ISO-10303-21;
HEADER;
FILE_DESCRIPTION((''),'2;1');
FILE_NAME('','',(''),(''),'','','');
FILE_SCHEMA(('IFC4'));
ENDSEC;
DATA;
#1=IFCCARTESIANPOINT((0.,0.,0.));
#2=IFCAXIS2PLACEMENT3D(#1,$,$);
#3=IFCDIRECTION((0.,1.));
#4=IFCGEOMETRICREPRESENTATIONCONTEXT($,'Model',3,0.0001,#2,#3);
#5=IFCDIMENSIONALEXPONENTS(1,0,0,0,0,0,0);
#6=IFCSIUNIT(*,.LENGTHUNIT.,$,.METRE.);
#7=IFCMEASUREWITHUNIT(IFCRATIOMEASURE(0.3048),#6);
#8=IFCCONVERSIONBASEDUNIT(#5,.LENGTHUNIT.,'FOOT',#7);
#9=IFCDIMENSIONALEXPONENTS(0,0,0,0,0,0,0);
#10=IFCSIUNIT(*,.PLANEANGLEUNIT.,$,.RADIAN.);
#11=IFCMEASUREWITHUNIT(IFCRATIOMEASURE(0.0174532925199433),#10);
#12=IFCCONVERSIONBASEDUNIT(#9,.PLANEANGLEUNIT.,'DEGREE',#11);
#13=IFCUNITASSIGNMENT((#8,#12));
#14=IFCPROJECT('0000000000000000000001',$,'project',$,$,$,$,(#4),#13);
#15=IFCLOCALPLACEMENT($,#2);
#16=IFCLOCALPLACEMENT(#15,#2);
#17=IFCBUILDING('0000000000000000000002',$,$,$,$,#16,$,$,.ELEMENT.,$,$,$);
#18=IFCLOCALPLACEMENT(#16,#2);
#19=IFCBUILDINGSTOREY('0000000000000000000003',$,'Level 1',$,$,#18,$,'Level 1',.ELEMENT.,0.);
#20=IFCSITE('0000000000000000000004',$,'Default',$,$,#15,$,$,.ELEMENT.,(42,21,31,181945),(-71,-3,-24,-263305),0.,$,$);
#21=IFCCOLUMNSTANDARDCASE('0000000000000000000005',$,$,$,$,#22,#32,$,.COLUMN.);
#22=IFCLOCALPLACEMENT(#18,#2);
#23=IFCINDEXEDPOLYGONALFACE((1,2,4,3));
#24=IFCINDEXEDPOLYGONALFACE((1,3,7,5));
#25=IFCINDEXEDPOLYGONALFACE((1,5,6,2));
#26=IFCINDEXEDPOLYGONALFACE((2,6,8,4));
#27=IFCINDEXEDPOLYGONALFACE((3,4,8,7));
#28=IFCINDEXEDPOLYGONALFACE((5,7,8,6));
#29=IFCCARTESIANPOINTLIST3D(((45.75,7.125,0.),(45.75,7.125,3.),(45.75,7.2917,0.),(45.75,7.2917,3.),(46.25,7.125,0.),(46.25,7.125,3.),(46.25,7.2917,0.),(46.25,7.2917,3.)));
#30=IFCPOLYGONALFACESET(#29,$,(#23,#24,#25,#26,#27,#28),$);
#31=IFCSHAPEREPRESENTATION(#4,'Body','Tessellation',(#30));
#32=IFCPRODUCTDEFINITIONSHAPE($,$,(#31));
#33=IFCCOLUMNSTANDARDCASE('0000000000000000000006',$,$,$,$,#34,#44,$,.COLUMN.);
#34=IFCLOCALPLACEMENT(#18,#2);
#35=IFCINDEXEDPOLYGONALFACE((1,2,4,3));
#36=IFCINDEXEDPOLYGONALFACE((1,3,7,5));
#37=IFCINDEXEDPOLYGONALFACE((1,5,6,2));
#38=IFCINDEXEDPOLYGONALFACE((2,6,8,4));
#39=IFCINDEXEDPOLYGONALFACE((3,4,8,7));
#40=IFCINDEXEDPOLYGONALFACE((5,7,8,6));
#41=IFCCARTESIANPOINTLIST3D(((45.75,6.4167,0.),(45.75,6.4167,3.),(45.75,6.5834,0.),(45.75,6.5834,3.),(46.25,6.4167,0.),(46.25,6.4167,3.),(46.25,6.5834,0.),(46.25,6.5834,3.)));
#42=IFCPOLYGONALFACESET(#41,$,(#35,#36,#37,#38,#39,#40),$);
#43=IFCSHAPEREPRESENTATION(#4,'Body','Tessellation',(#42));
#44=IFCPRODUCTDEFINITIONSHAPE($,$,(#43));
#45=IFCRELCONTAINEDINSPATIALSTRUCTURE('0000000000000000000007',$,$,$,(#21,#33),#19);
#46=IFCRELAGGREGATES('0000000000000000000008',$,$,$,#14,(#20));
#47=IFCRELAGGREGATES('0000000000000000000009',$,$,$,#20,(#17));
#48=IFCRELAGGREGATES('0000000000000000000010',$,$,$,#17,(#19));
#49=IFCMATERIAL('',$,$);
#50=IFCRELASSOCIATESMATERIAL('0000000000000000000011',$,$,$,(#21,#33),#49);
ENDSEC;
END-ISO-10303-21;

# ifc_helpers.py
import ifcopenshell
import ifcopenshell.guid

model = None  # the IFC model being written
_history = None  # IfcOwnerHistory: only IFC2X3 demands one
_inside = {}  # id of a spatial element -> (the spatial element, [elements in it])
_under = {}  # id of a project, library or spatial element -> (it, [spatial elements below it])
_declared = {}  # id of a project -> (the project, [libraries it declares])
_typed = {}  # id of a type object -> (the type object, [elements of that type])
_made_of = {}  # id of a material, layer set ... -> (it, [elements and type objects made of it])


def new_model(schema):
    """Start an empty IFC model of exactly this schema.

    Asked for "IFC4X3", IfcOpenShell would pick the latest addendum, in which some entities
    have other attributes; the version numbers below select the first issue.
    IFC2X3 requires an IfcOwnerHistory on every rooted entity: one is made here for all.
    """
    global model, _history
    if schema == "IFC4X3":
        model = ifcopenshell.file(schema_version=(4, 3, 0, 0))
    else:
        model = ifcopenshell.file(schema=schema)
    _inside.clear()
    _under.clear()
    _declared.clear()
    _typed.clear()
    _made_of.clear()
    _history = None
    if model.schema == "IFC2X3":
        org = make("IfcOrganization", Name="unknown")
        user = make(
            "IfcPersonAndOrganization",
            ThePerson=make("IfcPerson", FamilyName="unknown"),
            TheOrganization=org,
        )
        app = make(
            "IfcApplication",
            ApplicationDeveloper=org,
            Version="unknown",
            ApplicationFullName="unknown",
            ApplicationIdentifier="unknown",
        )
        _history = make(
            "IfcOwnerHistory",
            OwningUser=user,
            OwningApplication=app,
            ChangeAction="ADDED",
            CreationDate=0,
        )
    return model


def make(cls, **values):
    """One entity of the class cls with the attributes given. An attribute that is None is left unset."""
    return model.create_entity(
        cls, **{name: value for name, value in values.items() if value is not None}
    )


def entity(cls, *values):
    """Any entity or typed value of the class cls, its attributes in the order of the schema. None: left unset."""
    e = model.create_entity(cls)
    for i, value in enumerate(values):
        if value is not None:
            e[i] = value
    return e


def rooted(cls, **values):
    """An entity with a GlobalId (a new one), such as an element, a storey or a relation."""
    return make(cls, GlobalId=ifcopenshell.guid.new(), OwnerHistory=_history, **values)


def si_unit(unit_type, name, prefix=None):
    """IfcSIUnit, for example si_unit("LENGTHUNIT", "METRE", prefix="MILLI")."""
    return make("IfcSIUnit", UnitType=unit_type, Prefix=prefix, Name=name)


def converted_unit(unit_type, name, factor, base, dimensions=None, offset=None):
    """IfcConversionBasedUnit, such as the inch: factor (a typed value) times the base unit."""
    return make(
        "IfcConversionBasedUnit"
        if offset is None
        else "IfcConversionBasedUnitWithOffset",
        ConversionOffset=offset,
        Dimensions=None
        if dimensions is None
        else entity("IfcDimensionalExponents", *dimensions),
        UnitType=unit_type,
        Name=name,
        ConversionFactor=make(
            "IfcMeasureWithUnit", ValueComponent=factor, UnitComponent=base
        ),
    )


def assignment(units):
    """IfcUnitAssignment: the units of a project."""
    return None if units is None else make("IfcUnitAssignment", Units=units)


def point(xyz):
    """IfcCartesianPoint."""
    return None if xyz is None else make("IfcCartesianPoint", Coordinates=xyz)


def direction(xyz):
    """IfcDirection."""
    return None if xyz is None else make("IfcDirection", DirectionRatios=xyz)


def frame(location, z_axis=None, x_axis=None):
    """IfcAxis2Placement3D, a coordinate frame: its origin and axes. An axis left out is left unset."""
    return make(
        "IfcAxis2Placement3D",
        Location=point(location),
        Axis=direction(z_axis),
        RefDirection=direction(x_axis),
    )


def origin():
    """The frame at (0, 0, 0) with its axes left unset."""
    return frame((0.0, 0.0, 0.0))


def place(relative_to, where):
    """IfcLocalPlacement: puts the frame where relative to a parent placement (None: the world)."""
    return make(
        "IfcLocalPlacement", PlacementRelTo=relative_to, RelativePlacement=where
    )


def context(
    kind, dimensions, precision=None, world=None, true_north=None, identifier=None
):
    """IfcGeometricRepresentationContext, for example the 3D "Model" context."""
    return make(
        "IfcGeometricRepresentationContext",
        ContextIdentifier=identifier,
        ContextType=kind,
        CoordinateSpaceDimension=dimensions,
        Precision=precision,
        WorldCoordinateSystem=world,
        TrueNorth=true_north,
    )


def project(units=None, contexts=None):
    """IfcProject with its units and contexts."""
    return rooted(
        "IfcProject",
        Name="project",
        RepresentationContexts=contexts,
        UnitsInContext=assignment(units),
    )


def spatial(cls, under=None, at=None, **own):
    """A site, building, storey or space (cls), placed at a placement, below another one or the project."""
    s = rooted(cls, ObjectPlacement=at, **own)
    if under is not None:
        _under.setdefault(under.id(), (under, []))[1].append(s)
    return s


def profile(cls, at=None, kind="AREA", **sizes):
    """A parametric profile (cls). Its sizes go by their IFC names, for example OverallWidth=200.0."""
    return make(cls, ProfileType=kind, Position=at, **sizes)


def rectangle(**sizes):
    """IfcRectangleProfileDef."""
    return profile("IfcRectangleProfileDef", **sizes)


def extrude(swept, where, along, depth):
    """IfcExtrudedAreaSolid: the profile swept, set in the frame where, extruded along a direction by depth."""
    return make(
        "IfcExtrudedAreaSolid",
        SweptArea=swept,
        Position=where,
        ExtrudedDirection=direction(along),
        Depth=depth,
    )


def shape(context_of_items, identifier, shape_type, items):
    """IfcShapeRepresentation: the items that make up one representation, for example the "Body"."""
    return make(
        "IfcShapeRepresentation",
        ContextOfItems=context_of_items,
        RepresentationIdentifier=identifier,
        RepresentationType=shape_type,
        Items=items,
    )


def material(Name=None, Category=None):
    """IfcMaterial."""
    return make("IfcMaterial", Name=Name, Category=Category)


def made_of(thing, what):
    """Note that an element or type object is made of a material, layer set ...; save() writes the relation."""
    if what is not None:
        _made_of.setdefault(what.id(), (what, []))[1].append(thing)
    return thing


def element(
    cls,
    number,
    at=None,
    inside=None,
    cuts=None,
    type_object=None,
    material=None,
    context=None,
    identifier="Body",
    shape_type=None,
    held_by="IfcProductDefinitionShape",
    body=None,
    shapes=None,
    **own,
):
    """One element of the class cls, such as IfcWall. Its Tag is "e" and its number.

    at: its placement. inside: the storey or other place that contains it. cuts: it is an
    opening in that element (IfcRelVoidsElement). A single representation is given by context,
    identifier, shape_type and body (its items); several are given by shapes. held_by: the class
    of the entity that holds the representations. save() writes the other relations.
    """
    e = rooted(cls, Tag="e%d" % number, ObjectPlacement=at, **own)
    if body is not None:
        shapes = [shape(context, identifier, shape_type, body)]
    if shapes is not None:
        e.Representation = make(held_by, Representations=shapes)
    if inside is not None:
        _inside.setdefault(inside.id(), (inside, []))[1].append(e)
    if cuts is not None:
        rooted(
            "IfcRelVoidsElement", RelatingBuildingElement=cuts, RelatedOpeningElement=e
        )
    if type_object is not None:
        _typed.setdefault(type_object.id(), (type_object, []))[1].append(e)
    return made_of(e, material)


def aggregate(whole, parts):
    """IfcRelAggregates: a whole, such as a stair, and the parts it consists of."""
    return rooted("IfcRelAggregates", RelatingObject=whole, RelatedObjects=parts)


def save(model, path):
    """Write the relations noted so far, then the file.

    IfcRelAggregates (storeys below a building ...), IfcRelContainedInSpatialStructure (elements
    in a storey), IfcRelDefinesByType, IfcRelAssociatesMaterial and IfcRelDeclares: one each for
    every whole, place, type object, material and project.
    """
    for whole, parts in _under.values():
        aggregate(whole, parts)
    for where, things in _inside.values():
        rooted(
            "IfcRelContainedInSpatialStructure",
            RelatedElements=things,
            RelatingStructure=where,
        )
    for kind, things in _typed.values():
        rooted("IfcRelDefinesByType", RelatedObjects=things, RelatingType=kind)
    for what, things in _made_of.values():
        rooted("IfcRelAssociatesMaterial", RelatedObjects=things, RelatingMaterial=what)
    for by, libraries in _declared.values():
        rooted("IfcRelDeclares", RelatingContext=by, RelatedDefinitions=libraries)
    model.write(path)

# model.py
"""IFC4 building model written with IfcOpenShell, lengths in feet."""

from ifc_helpers import new_model, entity, si_unit, converted_unit, direction, frame, origin, place, context, project, spatial, rectangle, extrude, material, element, save


model = new_model("IFC4")

# Units and contexts
model_context = context("Model", 3, precision=0.0001, world=origin(), true_north=direction((0.0, 1.0)))
ifc_project = project(units=[converted_unit("LENGTHUNIT", "FOOT", entity("IfcRatioMeasure", 0.3048), si_unit("LENGTHUNIT", "METRE"), dimensions=[1, 0, 0, 0, 0, 0, 0]), converted_unit("PLANEANGLEUNIT", "DEGREE", entity("IfcRatioMeasure", 0.0174532925199433), si_unit("PLANEANGLEUNIT", "RADIAN"), dimensions=[0, 0, 0, 0, 0, 0, 0])], contexts=[model_context])

# Site, building, storey
site_placement = place(None, origin())
site = spatial("IfcSite", under=ifc_project, at=site_placement, Name="Default", CompositionType="ELEMENT", RefLatitude=(42, 21, 31, 181945), RefLongitude=(-71, -3, -24, -263305), RefElevation=0.0)
building_placement = place(site_placement, origin())
building = spatial("IfcBuilding", under=site, at=building_placement, CompositionType="ELEMENT")
storey_placement = place(building_placement, origin())
storey = spatial("IfcBuildingStorey", under=building, at=storey_placement, Name="Level 1", LongName="Level 1", CompositionType="ELEMENT", Elevation=0.0)

# Columns
ifc_material_1 = material(Name="")
placement = place(storey_placement, frame((46.0, 46.25, 0.0), z_axis=(0.0, 0.0, 1.0), x_axis=(0.0, -1.0, 0.0)))
for number, where, z_axis, x_axis in (
    (1, (39.0417, 0.0, 0.0), (0.0, 0.0, 1.0), (1.0, 0.0, 0.0)),
    (2, (39.75, 0.0, 0.0), (0.0, 0.0, 1.0), (1.0, 0.0, 0.0)),
):
    element("IfcColumnStandardCase", number, at=place(placement, frame(where, z_axis=z_axis, x_axis=x_axis)), inside=storey, material=ifc_material_1, PredefinedType="COLUMN", context=model_context, shape_type="SweptSolid", body=[
        extrude(rectangle(XDim=0.1667, YDim=0.5), origin(), (0.0, 0.0, 1.0), 3.0),
    ])

save(model, "model.ifc")
